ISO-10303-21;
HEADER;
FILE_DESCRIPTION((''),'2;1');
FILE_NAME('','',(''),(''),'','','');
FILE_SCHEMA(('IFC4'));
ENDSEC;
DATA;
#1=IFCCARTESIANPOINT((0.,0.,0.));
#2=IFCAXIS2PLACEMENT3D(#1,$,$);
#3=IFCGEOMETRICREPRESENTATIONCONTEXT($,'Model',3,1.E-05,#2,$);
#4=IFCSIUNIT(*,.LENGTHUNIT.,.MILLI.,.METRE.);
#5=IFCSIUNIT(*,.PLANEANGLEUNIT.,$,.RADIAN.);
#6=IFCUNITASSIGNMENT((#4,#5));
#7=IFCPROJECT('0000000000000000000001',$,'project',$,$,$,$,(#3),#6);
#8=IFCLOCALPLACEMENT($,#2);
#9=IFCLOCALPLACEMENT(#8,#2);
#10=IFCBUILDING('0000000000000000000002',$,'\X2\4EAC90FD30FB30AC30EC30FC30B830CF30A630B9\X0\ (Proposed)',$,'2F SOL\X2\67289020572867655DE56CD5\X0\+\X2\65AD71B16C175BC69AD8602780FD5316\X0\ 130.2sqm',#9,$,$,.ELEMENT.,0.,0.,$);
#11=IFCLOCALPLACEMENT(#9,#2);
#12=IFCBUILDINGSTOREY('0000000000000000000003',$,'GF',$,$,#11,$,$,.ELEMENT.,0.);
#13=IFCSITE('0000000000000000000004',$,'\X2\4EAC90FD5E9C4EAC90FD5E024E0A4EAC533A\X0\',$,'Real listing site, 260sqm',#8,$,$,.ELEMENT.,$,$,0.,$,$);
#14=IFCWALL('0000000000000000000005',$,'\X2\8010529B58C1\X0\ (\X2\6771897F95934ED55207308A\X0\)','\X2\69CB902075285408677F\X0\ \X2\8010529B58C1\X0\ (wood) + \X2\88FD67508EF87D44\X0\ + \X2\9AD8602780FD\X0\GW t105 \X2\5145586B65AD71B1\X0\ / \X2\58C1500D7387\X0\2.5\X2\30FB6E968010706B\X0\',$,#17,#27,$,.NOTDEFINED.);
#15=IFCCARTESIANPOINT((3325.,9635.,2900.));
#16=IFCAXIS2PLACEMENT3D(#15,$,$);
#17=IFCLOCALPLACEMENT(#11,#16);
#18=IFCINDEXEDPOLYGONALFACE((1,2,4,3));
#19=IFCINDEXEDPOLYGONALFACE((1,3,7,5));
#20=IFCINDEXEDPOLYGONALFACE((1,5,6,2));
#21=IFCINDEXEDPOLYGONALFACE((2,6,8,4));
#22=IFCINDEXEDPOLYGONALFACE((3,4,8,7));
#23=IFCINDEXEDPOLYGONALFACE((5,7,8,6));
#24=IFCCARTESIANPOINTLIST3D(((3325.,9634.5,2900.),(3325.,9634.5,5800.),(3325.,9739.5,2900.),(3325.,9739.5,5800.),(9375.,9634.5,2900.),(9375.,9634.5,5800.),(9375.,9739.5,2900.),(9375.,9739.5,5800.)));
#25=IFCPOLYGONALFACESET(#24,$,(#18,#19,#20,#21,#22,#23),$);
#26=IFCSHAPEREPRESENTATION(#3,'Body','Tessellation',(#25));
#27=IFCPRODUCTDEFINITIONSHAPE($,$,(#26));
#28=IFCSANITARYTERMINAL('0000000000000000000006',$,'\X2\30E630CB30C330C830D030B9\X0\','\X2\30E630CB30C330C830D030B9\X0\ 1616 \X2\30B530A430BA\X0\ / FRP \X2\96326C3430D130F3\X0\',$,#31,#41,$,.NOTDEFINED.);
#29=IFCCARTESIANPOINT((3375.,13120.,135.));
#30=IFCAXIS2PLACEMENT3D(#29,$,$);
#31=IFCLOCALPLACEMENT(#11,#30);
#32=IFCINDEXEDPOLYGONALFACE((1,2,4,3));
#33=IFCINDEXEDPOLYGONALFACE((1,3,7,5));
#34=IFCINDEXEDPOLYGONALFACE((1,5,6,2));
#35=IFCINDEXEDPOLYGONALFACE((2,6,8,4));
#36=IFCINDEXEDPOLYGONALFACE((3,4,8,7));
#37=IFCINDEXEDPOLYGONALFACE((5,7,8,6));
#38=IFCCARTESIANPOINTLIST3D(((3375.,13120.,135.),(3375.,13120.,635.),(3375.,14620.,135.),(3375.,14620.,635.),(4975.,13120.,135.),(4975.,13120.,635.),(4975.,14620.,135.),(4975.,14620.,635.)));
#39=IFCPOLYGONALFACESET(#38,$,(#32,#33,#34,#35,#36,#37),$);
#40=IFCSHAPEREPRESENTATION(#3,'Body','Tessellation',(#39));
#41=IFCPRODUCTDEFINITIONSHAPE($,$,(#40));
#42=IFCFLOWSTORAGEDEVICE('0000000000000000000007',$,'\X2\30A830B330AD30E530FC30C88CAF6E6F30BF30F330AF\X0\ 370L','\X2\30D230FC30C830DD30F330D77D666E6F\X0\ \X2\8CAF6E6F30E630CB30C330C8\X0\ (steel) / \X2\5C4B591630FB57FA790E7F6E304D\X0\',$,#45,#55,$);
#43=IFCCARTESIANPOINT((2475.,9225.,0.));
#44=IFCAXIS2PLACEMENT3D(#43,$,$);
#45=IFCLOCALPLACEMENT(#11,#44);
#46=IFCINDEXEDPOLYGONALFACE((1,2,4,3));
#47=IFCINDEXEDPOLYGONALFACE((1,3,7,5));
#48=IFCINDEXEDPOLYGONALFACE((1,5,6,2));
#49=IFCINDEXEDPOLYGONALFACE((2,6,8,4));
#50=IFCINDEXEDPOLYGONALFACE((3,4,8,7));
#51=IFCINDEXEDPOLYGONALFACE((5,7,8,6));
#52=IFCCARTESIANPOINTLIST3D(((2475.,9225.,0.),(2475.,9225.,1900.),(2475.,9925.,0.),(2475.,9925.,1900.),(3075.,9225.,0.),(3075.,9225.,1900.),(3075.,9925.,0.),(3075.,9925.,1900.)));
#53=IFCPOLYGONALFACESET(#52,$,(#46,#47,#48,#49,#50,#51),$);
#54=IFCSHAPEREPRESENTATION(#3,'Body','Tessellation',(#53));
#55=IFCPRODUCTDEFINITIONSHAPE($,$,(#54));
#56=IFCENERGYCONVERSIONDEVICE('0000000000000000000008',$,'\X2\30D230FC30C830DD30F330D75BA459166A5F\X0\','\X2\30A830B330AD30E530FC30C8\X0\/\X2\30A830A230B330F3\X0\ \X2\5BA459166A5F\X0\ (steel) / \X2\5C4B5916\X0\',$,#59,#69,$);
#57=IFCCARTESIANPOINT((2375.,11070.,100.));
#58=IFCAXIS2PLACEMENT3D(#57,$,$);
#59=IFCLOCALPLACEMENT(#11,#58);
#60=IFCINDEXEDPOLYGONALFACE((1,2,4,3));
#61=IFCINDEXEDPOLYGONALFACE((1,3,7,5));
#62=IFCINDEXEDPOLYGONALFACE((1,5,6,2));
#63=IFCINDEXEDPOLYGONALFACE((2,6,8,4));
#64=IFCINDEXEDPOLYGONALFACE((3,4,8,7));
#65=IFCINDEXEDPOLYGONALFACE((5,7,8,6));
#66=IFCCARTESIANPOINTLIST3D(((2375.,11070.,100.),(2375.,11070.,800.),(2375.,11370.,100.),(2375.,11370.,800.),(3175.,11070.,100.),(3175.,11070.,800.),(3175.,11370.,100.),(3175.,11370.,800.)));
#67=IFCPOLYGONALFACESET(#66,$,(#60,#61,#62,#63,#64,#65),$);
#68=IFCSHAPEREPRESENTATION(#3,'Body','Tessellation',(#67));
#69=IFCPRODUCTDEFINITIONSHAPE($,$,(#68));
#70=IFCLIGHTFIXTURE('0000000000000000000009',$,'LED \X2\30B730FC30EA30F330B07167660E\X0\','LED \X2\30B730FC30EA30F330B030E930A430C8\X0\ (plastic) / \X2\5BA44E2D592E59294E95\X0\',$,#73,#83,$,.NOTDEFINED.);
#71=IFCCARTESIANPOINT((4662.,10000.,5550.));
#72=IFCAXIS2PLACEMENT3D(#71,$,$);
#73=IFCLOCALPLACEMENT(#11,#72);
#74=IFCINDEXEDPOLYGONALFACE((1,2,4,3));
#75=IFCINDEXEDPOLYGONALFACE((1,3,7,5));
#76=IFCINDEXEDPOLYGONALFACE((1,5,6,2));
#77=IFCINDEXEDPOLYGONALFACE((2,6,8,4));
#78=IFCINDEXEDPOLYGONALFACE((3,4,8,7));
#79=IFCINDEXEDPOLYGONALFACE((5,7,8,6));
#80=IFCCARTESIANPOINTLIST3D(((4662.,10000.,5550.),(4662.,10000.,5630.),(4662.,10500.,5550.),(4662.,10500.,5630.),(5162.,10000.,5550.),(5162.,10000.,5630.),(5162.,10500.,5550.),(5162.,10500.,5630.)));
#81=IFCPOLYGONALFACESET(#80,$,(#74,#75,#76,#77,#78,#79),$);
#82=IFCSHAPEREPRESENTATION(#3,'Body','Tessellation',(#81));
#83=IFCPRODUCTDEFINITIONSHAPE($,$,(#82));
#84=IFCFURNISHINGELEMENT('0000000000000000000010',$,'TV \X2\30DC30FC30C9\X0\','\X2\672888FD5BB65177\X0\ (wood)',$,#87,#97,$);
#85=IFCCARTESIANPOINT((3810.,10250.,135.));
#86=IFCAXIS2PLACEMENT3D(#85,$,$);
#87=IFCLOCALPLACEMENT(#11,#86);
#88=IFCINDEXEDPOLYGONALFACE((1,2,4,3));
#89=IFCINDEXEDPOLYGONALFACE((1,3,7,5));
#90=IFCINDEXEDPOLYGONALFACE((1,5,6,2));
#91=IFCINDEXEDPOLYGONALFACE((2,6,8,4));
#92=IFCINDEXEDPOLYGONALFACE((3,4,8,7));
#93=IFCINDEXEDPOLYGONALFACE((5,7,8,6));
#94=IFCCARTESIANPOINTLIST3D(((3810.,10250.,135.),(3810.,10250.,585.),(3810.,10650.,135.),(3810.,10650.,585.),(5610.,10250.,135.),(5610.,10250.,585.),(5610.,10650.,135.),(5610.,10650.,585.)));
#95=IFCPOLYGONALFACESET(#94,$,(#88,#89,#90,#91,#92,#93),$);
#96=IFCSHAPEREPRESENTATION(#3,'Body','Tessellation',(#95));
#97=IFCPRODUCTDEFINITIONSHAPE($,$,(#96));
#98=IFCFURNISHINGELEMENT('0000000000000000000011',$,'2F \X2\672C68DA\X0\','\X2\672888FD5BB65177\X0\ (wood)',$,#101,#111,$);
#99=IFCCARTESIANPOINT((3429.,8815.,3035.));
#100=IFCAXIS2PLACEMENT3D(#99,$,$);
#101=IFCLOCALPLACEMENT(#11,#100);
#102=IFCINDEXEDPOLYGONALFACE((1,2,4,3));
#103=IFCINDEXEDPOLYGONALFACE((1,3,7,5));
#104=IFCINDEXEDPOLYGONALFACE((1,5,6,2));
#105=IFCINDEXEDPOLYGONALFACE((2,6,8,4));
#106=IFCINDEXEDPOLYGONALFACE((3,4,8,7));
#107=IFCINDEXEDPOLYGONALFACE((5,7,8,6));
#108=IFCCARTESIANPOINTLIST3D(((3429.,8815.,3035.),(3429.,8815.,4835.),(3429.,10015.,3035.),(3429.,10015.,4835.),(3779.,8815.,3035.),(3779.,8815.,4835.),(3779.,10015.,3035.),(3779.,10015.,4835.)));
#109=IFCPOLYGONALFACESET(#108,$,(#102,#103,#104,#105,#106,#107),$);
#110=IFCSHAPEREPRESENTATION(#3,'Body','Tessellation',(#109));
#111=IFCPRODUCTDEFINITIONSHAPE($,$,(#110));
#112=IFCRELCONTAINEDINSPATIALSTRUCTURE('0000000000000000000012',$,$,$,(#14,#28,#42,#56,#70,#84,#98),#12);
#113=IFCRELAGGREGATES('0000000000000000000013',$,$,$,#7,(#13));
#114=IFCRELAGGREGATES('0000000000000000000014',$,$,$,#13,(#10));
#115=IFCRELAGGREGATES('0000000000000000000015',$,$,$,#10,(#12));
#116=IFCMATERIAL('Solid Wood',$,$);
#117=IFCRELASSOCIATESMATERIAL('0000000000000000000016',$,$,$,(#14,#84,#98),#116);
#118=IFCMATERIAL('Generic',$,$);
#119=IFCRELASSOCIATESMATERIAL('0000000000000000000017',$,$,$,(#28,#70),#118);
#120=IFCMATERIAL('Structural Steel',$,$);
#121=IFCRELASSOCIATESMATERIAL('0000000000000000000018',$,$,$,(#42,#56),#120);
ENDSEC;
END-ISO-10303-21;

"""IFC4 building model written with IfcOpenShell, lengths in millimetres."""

from ifc_helpers import new_model, si_unit, frame, frame_2d, origin, place, context, project, spatial, rectangle, extrude, material, element, save


model = new_model("IFC4")

# Units and contexts
model_context = context("Model", 3, precision=1e-05, world=origin())
ifc_project = project(units=[si_unit("LENGTHUNIT", "METRE", prefix="MILLI"), si_unit("PLANEANGLEUNIT", "RADIAN")], contexts=[model_context])

# Site, building, storey
site_placement = place(None, origin())
site = spatial("IfcSite", under=ifc_project, at=site_placement, Name="京都府京都市上京区", ObjectType="Real listing site, 260sqm", CompositionType="ELEMENT", RefElevation=0.0)
building_placement = place(site_placement, origin())
building = spatial("IfcBuilding", under=site, at=building_placement, Name="京都・ガレージハウス (Proposed)", ObjectType="2F SOL木造在来工法+断熱気密高性能化 130.2sqm", CompositionType="ELEMENT", ElevationOfRefHeight=0.0, ElevationOfTerrain=0.0)
storey_placement = place(building_placement, origin())
storey = spatial("IfcBuildingStorey", under=building, at=storey_placement, Name="GF", CompositionType="ELEMENT", Elevation=0.0)

# Shared definitions
ifc_material_1 = material(Name="Solid Wood")

# Wall
wall_1_placement = place(storey_placement, frame((3325.0, 9635.0, 2900.0)))
element("IfcWall", 1, at=wall_1_placement, inside=storey, material=ifc_material_1, Name="耐力壁 (東西間仕切り)", Description="構造用合板 耐力壁 (wood) + 製材軸組 + 高性能GW t105 充填断熱 / 壁倍率2.5・準耐火", PredefinedType="NOTDEFINED", context=model_context, shape_type="SweptSolid", body=[
    extrude(rectangle(XDim=6050.0, YDim=105.0, at=frame_2d((3025.0, 52.0))), frame((3325.0, 9635.0, 2900.0)), (0.0, 0.0, 1.0), 2900.0),
])

# Sanitary terminal
ifc_material_2 = material(Name="Generic")
sanitary_terminal_placement = place(storey_placement, frame((3375.0, 13120.0, 135.0)))
element("IfcSanitaryTerminal", 2, at=sanitary_terminal_placement, inside=storey, material=ifc_material_2, Name="ユニットバス", Description="ユニットバス 1616 サイズ / FRP 防水パン", PredefinedType="NOTDEFINED", context=model_context, shape_type="SweptSolid", body=[
    extrude(rectangle(XDim=1600.0, YDim=1500.0, at=frame_2d((800.0, 750.0))), frame((3375.0, 13120.0, 135.0)), (0.0, 0.0, 1.0), 500.0),
])

# Flow storage device
ifc_material_3 = material(Name="Structural Steel")
flow_storage_device_placement = place(storey_placement, frame((2475.0, 9225.0, 0.0)))
element("IfcFlowStorageDevice", 3, at=flow_storage_device_placement, inside=storey, material=ifc_material_3, Name="エコキュート貯湯タンク 370L", Description="ヒートポンプ給湯 貯湯ユニット (steel) / 屋外・基礎置き", context=model_context, shape_type="SweptSolid", body=[
    extrude(rectangle(XDim=600.0, YDim=700.0, at=frame_2d((300.0, 350.0))), frame((2475.0, 9225.0, 0.0)), (0.0, 0.0, 1.0), 1900.0),
])

# Energy conversion device
energy_conversion_device_placement = place(storey_placement, frame((2375.0, 11070.0, 100.0)))
element("IfcEnergyConversionDevice", 4, at=energy_conversion_device_placement, inside=storey, material=ifc_material_3, Name="ヒートポンプ室外機", Description="エコキュート/エアコン 室外機 (steel) / 屋外", context=model_context, shape_type="SweptSolid", body=[
    extrude(rectangle(XDim=800.0, YDim=300.0, at=frame_2d((400.0, 150.0))), frame((2375.0, 11070.0, 100.0)), (0.0, 0.0, 1.0), 700.0),
])

# Light fixture
light_fixture_placement = place(storey_placement, frame((4662.0, 10000.0, 5550.0)))
element("IfcLightFixture", 5, at=light_fixture_placement, inside=storey, material=ifc_material_2, Name="LED シーリング照明", Description="LED シーリングライト (plastic) / 室中央天井", PredefinedType="NOTDEFINED", context=model_context, shape_type="SweptSolid", body=[
    extrude(rectangle(XDim=500.0, YDim=500.0, at=frame_2d((250.0, 250.0))), frame((4662.0, 10000.0, 5550.0)), (0.0, 0.0, 1.0), 80.0),
])

# Furnishing elements
furnishing_1_placement = place(storey_placement, frame((3810.0, 10250.0, 135.0)))
element("IfcFurnishingElement", 6, at=furnishing_1_placement, inside=storey, material=ifc_material_1, Name="TV ボード", Description="木製家具 (wood)", context=model_context, shape_type="SweptSolid", body=[
    extrude(rectangle(XDim=1800.0, YDim=400.0, at=frame_2d((900.0, 200.0))), frame((3810.0, 10250.0, 135.0)), (0.0, 0.0, 1.0), 450.0),
])
furnishing_2_placement = place(storey_placement, frame((3429.0, 8815.0, 3035.0)))
element("IfcFurnishingElement", 7, at=furnishing_2_placement, inside=storey, material=ifc_material_1, Name="2F 本棚", Description="木製家具 (wood)", context=model_context, shape_type="SweptSolid", body=[
    extrude(rectangle(XDim=350.0, YDim=1200.0, at=frame_2d((175.0, 600.0))), frame((3429.0, 8815.0, 3035.0)), (0.0, 0.0, 1.0), 1800.0),
])

save(model, "model.ifc")
